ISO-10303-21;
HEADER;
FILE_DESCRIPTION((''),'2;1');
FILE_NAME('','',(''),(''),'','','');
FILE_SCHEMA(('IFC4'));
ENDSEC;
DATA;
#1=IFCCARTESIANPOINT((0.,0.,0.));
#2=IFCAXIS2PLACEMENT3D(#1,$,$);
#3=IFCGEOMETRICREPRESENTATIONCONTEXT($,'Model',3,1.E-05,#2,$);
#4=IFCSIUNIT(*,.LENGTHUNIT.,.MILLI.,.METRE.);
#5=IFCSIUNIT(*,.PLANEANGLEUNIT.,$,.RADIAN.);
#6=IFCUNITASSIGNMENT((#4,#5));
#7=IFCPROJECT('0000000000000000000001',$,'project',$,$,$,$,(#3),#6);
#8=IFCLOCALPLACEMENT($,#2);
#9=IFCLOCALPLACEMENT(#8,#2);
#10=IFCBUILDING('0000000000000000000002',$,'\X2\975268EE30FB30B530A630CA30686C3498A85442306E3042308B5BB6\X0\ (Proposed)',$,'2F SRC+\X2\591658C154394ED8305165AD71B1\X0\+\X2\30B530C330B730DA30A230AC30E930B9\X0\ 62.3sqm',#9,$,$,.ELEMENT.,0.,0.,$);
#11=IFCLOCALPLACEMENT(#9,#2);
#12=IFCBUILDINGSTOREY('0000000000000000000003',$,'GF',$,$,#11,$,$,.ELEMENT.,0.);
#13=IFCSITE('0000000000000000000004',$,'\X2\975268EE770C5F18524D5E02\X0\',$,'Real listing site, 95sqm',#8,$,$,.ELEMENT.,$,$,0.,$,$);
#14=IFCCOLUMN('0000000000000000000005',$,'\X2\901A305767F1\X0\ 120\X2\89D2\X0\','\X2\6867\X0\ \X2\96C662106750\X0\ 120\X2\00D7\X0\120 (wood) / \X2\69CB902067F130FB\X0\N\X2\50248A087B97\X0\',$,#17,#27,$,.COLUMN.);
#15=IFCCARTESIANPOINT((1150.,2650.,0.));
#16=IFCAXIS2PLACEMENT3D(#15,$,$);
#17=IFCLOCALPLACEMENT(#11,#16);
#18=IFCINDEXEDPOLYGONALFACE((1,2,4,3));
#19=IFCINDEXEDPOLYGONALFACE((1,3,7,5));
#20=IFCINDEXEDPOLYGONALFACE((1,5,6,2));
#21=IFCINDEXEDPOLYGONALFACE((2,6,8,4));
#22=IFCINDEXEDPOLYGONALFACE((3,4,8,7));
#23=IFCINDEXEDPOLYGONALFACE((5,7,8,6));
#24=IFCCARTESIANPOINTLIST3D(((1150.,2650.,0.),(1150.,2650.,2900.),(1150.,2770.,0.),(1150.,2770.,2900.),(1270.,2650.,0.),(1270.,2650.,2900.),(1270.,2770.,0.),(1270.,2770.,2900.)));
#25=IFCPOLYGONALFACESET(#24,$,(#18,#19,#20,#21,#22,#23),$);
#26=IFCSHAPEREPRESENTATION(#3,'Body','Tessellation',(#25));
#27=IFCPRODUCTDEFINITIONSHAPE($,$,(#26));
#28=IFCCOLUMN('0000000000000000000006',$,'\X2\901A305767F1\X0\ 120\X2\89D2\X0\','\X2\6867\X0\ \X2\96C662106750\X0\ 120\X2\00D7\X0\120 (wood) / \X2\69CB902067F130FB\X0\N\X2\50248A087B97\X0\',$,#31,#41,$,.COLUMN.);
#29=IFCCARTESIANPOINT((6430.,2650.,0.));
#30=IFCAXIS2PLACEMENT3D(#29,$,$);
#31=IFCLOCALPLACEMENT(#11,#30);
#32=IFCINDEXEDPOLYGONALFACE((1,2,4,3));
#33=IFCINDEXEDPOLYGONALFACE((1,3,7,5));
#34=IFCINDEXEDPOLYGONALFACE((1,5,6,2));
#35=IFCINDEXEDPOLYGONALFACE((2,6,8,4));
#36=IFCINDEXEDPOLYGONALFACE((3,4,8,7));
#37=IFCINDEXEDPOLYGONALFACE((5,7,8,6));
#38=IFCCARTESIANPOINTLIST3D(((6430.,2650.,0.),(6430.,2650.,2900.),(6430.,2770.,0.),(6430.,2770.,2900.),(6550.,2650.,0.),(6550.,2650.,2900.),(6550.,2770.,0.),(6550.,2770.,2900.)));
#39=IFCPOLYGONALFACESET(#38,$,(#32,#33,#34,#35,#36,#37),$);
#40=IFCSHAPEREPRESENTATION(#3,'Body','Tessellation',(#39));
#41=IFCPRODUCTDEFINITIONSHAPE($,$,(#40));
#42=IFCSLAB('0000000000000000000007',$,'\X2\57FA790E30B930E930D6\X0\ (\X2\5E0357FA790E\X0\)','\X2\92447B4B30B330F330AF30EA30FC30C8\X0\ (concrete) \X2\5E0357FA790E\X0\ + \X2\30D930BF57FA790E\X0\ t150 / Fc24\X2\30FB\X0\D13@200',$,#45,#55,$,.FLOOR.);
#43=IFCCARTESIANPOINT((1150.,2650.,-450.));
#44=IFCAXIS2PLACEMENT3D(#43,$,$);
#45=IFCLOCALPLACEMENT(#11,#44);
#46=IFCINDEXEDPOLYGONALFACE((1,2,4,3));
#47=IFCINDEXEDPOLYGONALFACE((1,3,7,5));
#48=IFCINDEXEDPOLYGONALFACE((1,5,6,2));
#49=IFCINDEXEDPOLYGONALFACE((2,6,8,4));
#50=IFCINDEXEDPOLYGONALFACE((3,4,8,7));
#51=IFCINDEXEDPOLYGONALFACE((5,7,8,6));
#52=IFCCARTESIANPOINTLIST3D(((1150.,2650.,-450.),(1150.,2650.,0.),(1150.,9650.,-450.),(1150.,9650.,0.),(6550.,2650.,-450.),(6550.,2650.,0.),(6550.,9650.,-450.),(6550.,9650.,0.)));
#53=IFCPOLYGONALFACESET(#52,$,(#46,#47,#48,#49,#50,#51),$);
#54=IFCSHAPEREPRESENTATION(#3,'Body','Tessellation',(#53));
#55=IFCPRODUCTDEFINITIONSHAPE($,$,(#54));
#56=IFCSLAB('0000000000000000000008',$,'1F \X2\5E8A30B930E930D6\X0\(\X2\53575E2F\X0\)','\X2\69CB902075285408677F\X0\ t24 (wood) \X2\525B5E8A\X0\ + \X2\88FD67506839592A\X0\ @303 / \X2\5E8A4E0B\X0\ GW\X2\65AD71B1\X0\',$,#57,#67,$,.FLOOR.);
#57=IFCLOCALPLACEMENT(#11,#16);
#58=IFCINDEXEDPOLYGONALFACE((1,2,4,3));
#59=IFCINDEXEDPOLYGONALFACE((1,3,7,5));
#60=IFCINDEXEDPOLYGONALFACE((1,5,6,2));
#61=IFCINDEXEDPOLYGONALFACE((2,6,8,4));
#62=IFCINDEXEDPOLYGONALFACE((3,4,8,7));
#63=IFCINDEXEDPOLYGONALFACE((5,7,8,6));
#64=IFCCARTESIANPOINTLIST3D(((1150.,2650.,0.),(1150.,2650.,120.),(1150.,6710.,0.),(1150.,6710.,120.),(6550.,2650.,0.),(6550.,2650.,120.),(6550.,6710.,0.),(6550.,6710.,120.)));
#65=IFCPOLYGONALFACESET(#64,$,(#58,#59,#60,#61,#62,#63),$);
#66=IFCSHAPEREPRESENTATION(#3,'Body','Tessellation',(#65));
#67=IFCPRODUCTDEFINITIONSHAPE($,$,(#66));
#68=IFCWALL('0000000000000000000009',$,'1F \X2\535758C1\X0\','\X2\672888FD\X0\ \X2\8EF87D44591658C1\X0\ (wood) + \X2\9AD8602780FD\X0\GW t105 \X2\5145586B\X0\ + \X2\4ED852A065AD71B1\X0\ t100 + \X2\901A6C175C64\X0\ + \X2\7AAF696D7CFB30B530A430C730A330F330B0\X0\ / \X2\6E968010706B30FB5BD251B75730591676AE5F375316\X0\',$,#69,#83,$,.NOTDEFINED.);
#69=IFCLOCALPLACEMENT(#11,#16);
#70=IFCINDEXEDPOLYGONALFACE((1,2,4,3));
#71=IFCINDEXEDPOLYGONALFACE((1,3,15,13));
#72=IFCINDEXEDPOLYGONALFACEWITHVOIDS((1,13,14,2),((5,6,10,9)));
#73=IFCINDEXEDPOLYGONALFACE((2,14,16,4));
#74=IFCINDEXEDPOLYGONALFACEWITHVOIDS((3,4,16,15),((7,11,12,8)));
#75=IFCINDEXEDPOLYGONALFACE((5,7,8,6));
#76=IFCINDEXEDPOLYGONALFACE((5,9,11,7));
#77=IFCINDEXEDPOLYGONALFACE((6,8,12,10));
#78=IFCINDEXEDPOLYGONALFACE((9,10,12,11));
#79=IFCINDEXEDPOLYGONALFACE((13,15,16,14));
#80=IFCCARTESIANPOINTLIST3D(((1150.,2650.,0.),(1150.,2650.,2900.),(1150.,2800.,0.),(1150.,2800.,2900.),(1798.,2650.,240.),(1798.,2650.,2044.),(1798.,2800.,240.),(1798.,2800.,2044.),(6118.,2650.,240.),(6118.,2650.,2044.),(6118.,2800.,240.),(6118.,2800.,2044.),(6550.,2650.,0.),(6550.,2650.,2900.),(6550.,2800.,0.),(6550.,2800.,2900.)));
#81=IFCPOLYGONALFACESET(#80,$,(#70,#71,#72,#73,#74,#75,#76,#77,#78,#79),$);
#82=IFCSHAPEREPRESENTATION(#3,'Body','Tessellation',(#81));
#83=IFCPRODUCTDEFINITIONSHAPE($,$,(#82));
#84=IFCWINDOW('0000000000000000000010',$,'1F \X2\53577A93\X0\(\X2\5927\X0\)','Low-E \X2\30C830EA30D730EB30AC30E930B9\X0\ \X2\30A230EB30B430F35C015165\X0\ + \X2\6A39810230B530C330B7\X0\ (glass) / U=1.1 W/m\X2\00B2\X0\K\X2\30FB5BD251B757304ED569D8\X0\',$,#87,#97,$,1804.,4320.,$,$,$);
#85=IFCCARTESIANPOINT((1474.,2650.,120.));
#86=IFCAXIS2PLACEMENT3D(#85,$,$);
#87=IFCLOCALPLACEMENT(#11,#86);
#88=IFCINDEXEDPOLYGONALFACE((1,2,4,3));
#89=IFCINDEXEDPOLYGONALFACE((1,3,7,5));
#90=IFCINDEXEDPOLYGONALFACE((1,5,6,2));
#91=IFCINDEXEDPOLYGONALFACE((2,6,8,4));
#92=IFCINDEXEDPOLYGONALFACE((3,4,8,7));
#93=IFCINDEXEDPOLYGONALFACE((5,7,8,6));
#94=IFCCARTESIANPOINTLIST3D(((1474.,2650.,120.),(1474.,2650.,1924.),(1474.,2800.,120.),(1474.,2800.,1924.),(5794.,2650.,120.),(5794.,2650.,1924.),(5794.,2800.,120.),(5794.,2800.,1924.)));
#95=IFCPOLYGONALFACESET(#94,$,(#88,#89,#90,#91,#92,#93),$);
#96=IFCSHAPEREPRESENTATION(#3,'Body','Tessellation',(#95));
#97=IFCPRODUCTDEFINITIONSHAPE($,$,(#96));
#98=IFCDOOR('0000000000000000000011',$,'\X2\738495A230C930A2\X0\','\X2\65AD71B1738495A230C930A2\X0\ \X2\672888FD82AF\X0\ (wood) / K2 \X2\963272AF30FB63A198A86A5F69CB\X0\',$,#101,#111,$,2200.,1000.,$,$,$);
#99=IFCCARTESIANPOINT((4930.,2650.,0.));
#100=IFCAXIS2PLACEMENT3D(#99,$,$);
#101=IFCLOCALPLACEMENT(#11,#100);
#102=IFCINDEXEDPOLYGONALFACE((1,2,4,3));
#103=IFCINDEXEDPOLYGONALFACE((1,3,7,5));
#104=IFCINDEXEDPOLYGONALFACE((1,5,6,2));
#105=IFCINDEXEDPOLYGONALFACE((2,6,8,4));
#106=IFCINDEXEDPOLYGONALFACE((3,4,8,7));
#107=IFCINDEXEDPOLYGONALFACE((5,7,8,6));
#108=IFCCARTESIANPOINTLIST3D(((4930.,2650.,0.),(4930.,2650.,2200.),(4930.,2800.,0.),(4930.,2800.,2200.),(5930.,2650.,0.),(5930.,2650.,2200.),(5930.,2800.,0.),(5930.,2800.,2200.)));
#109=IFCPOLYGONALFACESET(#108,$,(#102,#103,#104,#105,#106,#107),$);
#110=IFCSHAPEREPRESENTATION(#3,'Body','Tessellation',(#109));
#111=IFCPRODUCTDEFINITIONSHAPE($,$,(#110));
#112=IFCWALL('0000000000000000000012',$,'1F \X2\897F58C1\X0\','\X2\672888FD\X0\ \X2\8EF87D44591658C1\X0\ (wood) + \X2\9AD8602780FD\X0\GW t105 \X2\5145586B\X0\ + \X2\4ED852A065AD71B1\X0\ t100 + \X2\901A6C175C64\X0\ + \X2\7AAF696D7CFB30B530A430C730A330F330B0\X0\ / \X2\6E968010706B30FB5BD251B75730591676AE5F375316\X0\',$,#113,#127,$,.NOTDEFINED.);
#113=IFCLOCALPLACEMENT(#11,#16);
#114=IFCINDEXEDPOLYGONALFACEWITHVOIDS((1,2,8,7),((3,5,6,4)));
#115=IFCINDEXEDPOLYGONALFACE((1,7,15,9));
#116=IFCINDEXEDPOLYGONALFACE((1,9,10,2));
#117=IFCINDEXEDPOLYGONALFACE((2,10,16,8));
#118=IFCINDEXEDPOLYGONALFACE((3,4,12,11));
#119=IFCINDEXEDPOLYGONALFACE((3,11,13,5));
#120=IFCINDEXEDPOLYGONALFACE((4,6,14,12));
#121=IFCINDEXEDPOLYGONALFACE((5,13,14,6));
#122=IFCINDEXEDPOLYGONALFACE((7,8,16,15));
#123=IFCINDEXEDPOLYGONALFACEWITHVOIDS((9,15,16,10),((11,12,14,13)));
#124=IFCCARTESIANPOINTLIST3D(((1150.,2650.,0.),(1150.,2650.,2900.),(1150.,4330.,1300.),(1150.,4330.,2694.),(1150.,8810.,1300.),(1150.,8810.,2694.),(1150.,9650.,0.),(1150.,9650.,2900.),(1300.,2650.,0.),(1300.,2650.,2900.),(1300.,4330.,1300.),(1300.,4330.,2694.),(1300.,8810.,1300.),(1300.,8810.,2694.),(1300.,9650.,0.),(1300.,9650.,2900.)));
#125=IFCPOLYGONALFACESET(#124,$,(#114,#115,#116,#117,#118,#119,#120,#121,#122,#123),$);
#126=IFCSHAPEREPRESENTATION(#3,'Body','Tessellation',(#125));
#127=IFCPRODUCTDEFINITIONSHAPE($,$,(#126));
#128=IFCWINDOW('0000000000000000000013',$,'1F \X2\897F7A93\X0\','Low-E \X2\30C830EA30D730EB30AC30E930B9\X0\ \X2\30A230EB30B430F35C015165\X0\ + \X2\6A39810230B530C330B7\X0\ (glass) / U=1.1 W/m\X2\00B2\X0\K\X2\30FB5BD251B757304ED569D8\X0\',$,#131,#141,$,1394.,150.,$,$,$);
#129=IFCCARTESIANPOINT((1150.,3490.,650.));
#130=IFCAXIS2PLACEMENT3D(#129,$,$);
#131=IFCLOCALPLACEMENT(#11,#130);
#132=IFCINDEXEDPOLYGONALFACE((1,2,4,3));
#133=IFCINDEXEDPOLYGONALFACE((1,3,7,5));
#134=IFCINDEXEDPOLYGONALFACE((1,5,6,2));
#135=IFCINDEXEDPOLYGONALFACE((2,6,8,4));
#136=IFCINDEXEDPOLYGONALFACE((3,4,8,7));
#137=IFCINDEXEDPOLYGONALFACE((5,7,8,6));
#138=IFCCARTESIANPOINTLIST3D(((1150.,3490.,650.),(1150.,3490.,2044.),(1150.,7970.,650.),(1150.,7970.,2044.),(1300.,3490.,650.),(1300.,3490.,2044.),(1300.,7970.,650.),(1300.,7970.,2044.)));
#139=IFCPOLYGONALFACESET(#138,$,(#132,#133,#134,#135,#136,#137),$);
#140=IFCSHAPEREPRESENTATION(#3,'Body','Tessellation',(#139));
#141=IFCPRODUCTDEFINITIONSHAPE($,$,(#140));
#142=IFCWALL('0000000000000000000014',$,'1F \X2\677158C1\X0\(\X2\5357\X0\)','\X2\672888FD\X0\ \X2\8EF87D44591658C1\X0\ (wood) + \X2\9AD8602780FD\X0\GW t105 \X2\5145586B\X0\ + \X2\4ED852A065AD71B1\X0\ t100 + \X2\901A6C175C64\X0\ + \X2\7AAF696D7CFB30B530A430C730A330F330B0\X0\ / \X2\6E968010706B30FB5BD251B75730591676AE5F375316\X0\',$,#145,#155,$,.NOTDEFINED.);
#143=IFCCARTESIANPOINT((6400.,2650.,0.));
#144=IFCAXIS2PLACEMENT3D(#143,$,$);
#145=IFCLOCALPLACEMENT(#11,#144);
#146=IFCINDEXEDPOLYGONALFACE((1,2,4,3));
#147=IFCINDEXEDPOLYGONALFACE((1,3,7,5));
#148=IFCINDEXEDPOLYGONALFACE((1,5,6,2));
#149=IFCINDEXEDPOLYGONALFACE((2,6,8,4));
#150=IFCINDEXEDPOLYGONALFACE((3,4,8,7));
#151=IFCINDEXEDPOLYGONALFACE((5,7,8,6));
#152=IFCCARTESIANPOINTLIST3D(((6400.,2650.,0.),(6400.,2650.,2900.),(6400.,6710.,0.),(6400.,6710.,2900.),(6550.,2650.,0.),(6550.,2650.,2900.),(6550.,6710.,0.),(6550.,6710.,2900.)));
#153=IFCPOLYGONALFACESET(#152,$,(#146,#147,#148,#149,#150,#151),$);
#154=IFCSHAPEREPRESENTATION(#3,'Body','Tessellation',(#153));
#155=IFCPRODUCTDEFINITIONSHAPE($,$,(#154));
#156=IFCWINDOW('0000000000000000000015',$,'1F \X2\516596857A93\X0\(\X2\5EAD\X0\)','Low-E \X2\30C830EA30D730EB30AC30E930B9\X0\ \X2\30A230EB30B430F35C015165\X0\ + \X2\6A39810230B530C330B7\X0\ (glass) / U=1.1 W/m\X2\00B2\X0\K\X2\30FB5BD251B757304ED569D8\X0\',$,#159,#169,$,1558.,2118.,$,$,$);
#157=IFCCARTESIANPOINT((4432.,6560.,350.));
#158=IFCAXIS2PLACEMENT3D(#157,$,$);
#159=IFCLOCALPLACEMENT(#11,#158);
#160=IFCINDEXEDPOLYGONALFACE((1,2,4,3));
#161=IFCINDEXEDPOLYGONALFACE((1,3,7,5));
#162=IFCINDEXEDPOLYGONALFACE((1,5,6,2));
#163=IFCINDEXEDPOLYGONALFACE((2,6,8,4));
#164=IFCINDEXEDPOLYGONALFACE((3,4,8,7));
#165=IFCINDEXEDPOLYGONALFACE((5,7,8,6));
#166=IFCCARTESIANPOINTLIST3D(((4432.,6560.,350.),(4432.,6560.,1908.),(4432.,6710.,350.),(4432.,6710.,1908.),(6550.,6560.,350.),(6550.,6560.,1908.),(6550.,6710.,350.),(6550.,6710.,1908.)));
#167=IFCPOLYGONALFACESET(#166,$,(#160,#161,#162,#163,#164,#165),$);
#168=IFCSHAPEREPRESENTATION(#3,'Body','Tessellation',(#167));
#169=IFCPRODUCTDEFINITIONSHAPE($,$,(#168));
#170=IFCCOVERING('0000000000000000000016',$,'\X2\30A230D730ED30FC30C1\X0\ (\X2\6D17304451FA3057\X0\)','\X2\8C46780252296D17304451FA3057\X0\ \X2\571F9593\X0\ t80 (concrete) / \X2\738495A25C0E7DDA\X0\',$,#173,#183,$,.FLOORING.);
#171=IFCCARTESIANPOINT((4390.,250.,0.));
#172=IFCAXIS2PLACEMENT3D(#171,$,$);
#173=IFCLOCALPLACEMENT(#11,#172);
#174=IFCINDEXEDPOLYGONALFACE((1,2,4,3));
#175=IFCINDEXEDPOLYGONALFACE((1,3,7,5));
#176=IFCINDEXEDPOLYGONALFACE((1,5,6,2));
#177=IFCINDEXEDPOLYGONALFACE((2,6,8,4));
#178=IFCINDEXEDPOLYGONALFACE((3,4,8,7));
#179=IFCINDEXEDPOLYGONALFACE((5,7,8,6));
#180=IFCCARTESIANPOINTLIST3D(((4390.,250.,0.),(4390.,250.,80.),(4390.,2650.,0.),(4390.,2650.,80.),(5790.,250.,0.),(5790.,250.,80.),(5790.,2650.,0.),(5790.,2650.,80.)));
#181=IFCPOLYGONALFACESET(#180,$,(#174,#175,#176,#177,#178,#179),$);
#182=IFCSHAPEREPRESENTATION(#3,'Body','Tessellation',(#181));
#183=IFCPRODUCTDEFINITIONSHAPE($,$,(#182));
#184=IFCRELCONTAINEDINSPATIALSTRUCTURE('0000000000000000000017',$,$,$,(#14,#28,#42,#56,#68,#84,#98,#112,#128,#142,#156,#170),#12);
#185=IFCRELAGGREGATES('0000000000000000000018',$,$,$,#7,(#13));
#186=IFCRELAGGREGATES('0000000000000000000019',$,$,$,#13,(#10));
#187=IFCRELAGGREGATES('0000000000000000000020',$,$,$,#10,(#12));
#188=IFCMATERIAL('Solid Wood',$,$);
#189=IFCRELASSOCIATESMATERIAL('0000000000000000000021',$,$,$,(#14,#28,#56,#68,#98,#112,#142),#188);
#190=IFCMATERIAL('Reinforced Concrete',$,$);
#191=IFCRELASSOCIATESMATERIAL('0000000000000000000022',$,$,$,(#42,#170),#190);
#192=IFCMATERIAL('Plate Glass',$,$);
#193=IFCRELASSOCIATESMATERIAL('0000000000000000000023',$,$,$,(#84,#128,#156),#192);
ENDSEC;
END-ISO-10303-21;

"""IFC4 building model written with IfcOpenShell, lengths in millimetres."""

from ifc_helpers import new_model, si_unit, frame, frame_2d, origin, place, context, project, spatial, rectangle, extrude, material, element, fill, save


model = new_model("IFC4")

# Units and contexts
model_context = context("Model", 3, precision=1e-05, world=origin())
ifc_project = project(units=[si_unit("LENGTHUNIT", "METRE", prefix="MILLI"), si_unit("PLANEANGLEUNIT", "RADIAN")], contexts=[model_context])

# Site, building, storey
site_placement = place(None, origin())
site = spatial("IfcSite", under=ifc_project, at=site_placement, Name="青森県弘前市", ObjectType="Real listing site, 95sqm", CompositionType="ELEMENT", RefElevation=0.0)
building_placement = place(site_placement, origin())
building = spatial("IfcBuilding", under=site, at=building_placement, Name="青森・サウナと水風呂のある家 (Proposed)", ObjectType="2F SRC+外壁吹付け断熱+サッシペアガラス 62.3sqm", CompositionType="ELEMENT", ElevationOfRefHeight=0.0, ElevationOfTerrain=0.0)
storey_placement = place(building_placement, origin())
storey = spatial("IfcBuildingStorey", under=building, at=storey_placement, Name="GF", CompositionType="ELEMENT", Elevation=0.0)

# Columns
ifc_material_1 = material(Name="Solid Wood")
column_1_placement = place(storey_placement, frame((1150.0, 2650.0, 0.0)))
element("IfcColumn", 1, at=column_1_placement, inside=storey, material=ifc_material_1, Name="通し柱 120角", Description="桧 集成材 120×120 (wood) / 構造柱・N値計算", PredefinedType="COLUMN", context=model_context, shape_type="SweptSolid", body=[
    extrude(rectangle(XDim=120.0, YDim=120.0, at=frame_2d((60.0, 60.0))), frame((1150.0, 2650.0, 0.0)), (0.0, 0.0, 1.0), 2900.0),
])
column_2_placement = place(storey_placement, frame((6430.0, 2650.0, 0.0)))
element("IfcColumn", 2, at=column_2_placement, inside=storey, material=ifc_material_1, Name="通し柱 120角", Description="桧 集成材 120×120 (wood) / 構造柱・N値計算", PredefinedType="COLUMN", context=model_context, shape_type="SweptSolid", body=[
    extrude(rectangle(XDim=120.0, YDim=120.0, at=frame_2d((60.0, 60.0))), frame((6430.0, 2650.0, 0.0)), (0.0, 0.0, 1.0), 2900.0),
])

# Slabs
ifc_material_2 = material(Name="Reinforced Concrete")
slab_1_placement = place(storey_placement, frame((1150.0, 2650.0, -450.0)))
element("IfcSlab", 3, at=slab_1_placement, inside=storey, material=ifc_material_2, Name="基礎スラブ (布基礎)", Description="鉄筋コンクリート (concrete) 布基礎 + ベタ基礎 t150 / Fc24・D13@200", PredefinedType="FLOOR", context=model_context, shape_type="SweptSolid", body=[
    extrude(rectangle(XDim=5400.0, YDim=7000.0, at=frame_2d((2700.0, 3500.0))), frame((1150.0, 2650.0, -450.0)), (0.0, 0.0, 1.0), 450.0),
])
slab_2_placement = place(storey_placement, frame((1150.0, 2650.0, 0.0)))
element("IfcSlab", 4, at=slab_2_placement, inside=storey, material=ifc_material_1, Name="1F 床スラブ(南帯)", Description="構造用合板 t24 (wood) 剛床 + 製材根太 @303 / 床下 GW断熱", PredefinedType="FLOOR", context=model_context, shape_type="SweptSolid", body=[
    extrude(rectangle(XDim=5400.0, YDim=4060.0, at=frame_2d((2700.0, 2030.0))), frame((1150.0, 2650.0, 0.0)), (0.0, 0.0, 1.0), 120.0),
])

# Wall, openings, window, door
wall_1_placement = place(storey_placement, frame((1150.0, 2650.0, 0.0)))
wall_1 = element("IfcWall", 5, at=wall_1_placement, inside=storey, material=ifc_material_1, Name="1F 南壁", Description="木製 軸組外壁 (wood) + 高性能GW t105 充填 + 付加断熱 t100 + 通気層 + 窯業系サイディング / 準耐火・寒冷地外皮強化", PredefinedType="NOTDEFINED", context=model_context, shape_type="SweptSolid", body=[
    extrude(rectangle(XDim=5400.0, YDim=150.0, at=frame_2d((2700.0, 75.0))), frame((1150.0, 2650.0, 0.0)), (0.0, 0.0, 1.0), 2900.0),
])
opening_1_placement = place(storey_placement, frame((1474.0, 2650.0, 120.0)))
opening_1 = element("IfcOpeningElement", 6, at=opening_1_placement, cuts=wall_1, PredefinedType="NOTDEFINED", context=model_context, shape_type="SweptSolid", body=[
    extrude(rectangle(XDim=4320.0, YDim=150.0, at=frame_2d((2160.0, 75.0))), frame((1474.0, 2650.0, 120.0)), (0.0, 0.0, 1.0), 1804.0),
])
opening_2_placement = place(storey_placement, frame((4930.0, 2650.0, 0.0)))
opening_2 = element("IfcOpeningElement", 7, at=opening_2_placement, cuts=wall_1, PredefinedType="NOTDEFINED", context=model_context, shape_type="SweptSolid", body=[
    extrude(rectangle(XDim=1000.0, YDim=150.0, at=frame_2d((500.0, 75.0))), frame((4930.0, 2650.0, 0.0)), (0.0, 0.0, 1.0), 2200.0),
])
ifc_material_3 = material(Name="Plate Glass")
window_1_placement = place(storey_placement, frame((1474.0, 2650.0, 120.0)))
window_1 = element("IfcWindow", 8, at=window_1_placement, inside=storey, material=ifc_material_3, Name="1F 南窓(大)", Description="Low-E トリプルガラス アルゴン封入 + 樹脂サッシ (glass) / U=1.1 W/m²K・寒冷地仕様", OverallHeight=1804.0, OverallWidth=4320.0, context=model_context, shape_type="SweptSolid", body=[
    extrude(rectangle(XDim=4320.0, YDim=150.0, at=frame_2d((2160.0, 75.0))), frame((1474.0, 2650.0, 120.0)), (0.0, 0.0, 1.0), 1804.0),
])
fill(opening_1, window_1)
door_1_placement = place(storey_placement, frame((4930.0, 2650.0, 0.0)))
door_1 = element("IfcDoor", 9, at=door_1_placement, inside=storey, material=ifc_material_1, Name="玄関ドア", Description="断熱玄関ドア 木製芯 (wood) / K2 防犯・採風機構", OverallHeight=2200.0, OverallWidth=1000.0, context=model_context, shape_type="SweptSolid", body=[
    extrude(rectangle(XDim=1000.0, YDim=150.0, at=frame_2d((500.0, 75.0))), frame((4930.0, 2650.0, 0.0)), (0.0, 0.0, 1.0), 2200.0),
])
fill(opening_2, door_1)

# Walls, openings, windows
wall_2_placement = place(storey_placement, frame((1150.0, 2650.0, 0.0)))
wall_2 = element("IfcWall", 10, at=wall_2_placement, inside=storey, material=ifc_material_1, Name="1F 西壁", Description="木製 軸組外壁 (wood) + 高性能GW t105 充填 + 付加断熱 t100 + 通気層 + 窯業系サイディング / 準耐火・寒冷地外皮強化", PredefinedType="NOTDEFINED", context=model_context, shape_type="SweptSolid", body=[
    extrude(rectangle(XDim=150.0, YDim=7000.0, at=frame_2d((75.0, 3500.0))), frame((1150.0, 2650.0, 0.0)), (0.0, 0.0, 1.0), 2900.0),
])
opening_3_placement = place(storey_placement, frame((1150.0, 3490.0, 650.0)))
opening_3 = element("IfcOpeningElement", 11, at=opening_3_placement, cuts=wall_2, PredefinedType="NOTDEFINED", context=model_context, shape_type="SweptSolid", body=[
    extrude(rectangle(XDim=150.0, YDim=4480.0, at=frame_2d((75.0, 2240.0))), frame((1150.0, 3490.0, 650.0)), (0.0, 0.0, 1.0), 1394.0),
])
window_2_placement = place(storey_placement, frame((1150.0, 3490.0, 650.0)))
window_2 = element("IfcWindow", 12, at=window_2_placement, inside=storey, material=ifc_material_3, Name="1F 西窓", Description="Low-E トリプルガラス アルゴン封入 + 樹脂サッシ (glass) / U=1.1 W/m²K・寒冷地仕様", OverallHeight=1394.0, OverallWidth=150.0, context=model_context, shape_type="SweptSolid", body=[
    extrude(rectangle(XDim=150.0, YDim=4480.0, at=frame_2d((75.0, 2240.0))), frame((1150.0, 3490.0, 650.0)), (0.0, 0.0, 1.0), 1394.0),
])
fill(opening_3, window_2)
wall_3_placement = place(storey_placement, frame((6400.0, 2650.0, 0.0)))
wall_3 = element("IfcWall", 13, at=wall_3_placement, inside=storey, material=ifc_material_1, Name="1F 東壁(南)", Description="木製 軸組外壁 (wood) + 高性能GW t105 充填 + 付加断熱 t100 + 通気層 + 窯業系サイディング / 準耐火・寒冷地外皮強化", PredefinedType="NOTDEFINED", context=model_context, shape_type="SweptSolid", body=[
    extrude(rectangle(XDim=150.0, YDim=4060.0, at=frame_2d((75.0, 2030.0))), frame((6400.0, 2650.0, 0.0)), (0.0, 0.0, 1.0), 2900.0),
])
opening_4_placement = place(storey_placement, frame((4432.0, 6560.0, 350.0)))
opening_4 = element("IfcOpeningElement", 14, at=opening_4_placement, cuts=wall_3, PredefinedType="NOTDEFINED", context=model_context, shape_type="SweptSolid", body=[
    extrude(rectangle(XDim=2118.0, YDim=150.0, at=frame_2d((1059.0, 75.0))), frame((4432.0, 6560.0, 350.0)), (0.0, 0.0, 1.0), 1558.0),
])
window_3_placement = place(storey_placement, frame((4432.0, 6560.0, 350.0)))
window_3 = element("IfcWindow", 15, at=window_3_placement, inside=storey, material=ifc_material_3, Name="1F 入隅窓(庭)", Description="Low-E トリプルガラス アルゴン封入 + 樹脂サッシ (glass) / U=1.1 W/m²K・寒冷地仕様", OverallHeight=1558.0, OverallWidth=2118.0, context=model_context, shape_type="SweptSolid", body=[
    extrude(rectangle(XDim=2118.0, YDim=150.0, at=frame_2d((1059.0, 75.0))), frame((4432.0, 6560.0, 350.0)), (0.0, 0.0, 1.0), 1558.0),
])
fill(opening_4, window_3)

# Covering
covering_1_placement = place(storey_placement, frame((4390.0, 250.0, 0.0)))
element("IfcCovering", 16, at=covering_1_placement, inside=storey, material=ifc_material_2, Name="アプローチ (洗い出し)", Description="豆砂利洗い出し 土間 t80 (concrete) / 玄関導線", PredefinedType="FLOORING", context=model_context, shape_type="SweptSolid", body=[
    extrude(rectangle(XDim=1400.0, YDim=2400.0, at=frame_2d((700.0, 1200.0))), frame((4390.0, 250.0, 0.0)), (0.0, 0.0, 1.0), 80.0),
])

save(model, "model.ifc")
